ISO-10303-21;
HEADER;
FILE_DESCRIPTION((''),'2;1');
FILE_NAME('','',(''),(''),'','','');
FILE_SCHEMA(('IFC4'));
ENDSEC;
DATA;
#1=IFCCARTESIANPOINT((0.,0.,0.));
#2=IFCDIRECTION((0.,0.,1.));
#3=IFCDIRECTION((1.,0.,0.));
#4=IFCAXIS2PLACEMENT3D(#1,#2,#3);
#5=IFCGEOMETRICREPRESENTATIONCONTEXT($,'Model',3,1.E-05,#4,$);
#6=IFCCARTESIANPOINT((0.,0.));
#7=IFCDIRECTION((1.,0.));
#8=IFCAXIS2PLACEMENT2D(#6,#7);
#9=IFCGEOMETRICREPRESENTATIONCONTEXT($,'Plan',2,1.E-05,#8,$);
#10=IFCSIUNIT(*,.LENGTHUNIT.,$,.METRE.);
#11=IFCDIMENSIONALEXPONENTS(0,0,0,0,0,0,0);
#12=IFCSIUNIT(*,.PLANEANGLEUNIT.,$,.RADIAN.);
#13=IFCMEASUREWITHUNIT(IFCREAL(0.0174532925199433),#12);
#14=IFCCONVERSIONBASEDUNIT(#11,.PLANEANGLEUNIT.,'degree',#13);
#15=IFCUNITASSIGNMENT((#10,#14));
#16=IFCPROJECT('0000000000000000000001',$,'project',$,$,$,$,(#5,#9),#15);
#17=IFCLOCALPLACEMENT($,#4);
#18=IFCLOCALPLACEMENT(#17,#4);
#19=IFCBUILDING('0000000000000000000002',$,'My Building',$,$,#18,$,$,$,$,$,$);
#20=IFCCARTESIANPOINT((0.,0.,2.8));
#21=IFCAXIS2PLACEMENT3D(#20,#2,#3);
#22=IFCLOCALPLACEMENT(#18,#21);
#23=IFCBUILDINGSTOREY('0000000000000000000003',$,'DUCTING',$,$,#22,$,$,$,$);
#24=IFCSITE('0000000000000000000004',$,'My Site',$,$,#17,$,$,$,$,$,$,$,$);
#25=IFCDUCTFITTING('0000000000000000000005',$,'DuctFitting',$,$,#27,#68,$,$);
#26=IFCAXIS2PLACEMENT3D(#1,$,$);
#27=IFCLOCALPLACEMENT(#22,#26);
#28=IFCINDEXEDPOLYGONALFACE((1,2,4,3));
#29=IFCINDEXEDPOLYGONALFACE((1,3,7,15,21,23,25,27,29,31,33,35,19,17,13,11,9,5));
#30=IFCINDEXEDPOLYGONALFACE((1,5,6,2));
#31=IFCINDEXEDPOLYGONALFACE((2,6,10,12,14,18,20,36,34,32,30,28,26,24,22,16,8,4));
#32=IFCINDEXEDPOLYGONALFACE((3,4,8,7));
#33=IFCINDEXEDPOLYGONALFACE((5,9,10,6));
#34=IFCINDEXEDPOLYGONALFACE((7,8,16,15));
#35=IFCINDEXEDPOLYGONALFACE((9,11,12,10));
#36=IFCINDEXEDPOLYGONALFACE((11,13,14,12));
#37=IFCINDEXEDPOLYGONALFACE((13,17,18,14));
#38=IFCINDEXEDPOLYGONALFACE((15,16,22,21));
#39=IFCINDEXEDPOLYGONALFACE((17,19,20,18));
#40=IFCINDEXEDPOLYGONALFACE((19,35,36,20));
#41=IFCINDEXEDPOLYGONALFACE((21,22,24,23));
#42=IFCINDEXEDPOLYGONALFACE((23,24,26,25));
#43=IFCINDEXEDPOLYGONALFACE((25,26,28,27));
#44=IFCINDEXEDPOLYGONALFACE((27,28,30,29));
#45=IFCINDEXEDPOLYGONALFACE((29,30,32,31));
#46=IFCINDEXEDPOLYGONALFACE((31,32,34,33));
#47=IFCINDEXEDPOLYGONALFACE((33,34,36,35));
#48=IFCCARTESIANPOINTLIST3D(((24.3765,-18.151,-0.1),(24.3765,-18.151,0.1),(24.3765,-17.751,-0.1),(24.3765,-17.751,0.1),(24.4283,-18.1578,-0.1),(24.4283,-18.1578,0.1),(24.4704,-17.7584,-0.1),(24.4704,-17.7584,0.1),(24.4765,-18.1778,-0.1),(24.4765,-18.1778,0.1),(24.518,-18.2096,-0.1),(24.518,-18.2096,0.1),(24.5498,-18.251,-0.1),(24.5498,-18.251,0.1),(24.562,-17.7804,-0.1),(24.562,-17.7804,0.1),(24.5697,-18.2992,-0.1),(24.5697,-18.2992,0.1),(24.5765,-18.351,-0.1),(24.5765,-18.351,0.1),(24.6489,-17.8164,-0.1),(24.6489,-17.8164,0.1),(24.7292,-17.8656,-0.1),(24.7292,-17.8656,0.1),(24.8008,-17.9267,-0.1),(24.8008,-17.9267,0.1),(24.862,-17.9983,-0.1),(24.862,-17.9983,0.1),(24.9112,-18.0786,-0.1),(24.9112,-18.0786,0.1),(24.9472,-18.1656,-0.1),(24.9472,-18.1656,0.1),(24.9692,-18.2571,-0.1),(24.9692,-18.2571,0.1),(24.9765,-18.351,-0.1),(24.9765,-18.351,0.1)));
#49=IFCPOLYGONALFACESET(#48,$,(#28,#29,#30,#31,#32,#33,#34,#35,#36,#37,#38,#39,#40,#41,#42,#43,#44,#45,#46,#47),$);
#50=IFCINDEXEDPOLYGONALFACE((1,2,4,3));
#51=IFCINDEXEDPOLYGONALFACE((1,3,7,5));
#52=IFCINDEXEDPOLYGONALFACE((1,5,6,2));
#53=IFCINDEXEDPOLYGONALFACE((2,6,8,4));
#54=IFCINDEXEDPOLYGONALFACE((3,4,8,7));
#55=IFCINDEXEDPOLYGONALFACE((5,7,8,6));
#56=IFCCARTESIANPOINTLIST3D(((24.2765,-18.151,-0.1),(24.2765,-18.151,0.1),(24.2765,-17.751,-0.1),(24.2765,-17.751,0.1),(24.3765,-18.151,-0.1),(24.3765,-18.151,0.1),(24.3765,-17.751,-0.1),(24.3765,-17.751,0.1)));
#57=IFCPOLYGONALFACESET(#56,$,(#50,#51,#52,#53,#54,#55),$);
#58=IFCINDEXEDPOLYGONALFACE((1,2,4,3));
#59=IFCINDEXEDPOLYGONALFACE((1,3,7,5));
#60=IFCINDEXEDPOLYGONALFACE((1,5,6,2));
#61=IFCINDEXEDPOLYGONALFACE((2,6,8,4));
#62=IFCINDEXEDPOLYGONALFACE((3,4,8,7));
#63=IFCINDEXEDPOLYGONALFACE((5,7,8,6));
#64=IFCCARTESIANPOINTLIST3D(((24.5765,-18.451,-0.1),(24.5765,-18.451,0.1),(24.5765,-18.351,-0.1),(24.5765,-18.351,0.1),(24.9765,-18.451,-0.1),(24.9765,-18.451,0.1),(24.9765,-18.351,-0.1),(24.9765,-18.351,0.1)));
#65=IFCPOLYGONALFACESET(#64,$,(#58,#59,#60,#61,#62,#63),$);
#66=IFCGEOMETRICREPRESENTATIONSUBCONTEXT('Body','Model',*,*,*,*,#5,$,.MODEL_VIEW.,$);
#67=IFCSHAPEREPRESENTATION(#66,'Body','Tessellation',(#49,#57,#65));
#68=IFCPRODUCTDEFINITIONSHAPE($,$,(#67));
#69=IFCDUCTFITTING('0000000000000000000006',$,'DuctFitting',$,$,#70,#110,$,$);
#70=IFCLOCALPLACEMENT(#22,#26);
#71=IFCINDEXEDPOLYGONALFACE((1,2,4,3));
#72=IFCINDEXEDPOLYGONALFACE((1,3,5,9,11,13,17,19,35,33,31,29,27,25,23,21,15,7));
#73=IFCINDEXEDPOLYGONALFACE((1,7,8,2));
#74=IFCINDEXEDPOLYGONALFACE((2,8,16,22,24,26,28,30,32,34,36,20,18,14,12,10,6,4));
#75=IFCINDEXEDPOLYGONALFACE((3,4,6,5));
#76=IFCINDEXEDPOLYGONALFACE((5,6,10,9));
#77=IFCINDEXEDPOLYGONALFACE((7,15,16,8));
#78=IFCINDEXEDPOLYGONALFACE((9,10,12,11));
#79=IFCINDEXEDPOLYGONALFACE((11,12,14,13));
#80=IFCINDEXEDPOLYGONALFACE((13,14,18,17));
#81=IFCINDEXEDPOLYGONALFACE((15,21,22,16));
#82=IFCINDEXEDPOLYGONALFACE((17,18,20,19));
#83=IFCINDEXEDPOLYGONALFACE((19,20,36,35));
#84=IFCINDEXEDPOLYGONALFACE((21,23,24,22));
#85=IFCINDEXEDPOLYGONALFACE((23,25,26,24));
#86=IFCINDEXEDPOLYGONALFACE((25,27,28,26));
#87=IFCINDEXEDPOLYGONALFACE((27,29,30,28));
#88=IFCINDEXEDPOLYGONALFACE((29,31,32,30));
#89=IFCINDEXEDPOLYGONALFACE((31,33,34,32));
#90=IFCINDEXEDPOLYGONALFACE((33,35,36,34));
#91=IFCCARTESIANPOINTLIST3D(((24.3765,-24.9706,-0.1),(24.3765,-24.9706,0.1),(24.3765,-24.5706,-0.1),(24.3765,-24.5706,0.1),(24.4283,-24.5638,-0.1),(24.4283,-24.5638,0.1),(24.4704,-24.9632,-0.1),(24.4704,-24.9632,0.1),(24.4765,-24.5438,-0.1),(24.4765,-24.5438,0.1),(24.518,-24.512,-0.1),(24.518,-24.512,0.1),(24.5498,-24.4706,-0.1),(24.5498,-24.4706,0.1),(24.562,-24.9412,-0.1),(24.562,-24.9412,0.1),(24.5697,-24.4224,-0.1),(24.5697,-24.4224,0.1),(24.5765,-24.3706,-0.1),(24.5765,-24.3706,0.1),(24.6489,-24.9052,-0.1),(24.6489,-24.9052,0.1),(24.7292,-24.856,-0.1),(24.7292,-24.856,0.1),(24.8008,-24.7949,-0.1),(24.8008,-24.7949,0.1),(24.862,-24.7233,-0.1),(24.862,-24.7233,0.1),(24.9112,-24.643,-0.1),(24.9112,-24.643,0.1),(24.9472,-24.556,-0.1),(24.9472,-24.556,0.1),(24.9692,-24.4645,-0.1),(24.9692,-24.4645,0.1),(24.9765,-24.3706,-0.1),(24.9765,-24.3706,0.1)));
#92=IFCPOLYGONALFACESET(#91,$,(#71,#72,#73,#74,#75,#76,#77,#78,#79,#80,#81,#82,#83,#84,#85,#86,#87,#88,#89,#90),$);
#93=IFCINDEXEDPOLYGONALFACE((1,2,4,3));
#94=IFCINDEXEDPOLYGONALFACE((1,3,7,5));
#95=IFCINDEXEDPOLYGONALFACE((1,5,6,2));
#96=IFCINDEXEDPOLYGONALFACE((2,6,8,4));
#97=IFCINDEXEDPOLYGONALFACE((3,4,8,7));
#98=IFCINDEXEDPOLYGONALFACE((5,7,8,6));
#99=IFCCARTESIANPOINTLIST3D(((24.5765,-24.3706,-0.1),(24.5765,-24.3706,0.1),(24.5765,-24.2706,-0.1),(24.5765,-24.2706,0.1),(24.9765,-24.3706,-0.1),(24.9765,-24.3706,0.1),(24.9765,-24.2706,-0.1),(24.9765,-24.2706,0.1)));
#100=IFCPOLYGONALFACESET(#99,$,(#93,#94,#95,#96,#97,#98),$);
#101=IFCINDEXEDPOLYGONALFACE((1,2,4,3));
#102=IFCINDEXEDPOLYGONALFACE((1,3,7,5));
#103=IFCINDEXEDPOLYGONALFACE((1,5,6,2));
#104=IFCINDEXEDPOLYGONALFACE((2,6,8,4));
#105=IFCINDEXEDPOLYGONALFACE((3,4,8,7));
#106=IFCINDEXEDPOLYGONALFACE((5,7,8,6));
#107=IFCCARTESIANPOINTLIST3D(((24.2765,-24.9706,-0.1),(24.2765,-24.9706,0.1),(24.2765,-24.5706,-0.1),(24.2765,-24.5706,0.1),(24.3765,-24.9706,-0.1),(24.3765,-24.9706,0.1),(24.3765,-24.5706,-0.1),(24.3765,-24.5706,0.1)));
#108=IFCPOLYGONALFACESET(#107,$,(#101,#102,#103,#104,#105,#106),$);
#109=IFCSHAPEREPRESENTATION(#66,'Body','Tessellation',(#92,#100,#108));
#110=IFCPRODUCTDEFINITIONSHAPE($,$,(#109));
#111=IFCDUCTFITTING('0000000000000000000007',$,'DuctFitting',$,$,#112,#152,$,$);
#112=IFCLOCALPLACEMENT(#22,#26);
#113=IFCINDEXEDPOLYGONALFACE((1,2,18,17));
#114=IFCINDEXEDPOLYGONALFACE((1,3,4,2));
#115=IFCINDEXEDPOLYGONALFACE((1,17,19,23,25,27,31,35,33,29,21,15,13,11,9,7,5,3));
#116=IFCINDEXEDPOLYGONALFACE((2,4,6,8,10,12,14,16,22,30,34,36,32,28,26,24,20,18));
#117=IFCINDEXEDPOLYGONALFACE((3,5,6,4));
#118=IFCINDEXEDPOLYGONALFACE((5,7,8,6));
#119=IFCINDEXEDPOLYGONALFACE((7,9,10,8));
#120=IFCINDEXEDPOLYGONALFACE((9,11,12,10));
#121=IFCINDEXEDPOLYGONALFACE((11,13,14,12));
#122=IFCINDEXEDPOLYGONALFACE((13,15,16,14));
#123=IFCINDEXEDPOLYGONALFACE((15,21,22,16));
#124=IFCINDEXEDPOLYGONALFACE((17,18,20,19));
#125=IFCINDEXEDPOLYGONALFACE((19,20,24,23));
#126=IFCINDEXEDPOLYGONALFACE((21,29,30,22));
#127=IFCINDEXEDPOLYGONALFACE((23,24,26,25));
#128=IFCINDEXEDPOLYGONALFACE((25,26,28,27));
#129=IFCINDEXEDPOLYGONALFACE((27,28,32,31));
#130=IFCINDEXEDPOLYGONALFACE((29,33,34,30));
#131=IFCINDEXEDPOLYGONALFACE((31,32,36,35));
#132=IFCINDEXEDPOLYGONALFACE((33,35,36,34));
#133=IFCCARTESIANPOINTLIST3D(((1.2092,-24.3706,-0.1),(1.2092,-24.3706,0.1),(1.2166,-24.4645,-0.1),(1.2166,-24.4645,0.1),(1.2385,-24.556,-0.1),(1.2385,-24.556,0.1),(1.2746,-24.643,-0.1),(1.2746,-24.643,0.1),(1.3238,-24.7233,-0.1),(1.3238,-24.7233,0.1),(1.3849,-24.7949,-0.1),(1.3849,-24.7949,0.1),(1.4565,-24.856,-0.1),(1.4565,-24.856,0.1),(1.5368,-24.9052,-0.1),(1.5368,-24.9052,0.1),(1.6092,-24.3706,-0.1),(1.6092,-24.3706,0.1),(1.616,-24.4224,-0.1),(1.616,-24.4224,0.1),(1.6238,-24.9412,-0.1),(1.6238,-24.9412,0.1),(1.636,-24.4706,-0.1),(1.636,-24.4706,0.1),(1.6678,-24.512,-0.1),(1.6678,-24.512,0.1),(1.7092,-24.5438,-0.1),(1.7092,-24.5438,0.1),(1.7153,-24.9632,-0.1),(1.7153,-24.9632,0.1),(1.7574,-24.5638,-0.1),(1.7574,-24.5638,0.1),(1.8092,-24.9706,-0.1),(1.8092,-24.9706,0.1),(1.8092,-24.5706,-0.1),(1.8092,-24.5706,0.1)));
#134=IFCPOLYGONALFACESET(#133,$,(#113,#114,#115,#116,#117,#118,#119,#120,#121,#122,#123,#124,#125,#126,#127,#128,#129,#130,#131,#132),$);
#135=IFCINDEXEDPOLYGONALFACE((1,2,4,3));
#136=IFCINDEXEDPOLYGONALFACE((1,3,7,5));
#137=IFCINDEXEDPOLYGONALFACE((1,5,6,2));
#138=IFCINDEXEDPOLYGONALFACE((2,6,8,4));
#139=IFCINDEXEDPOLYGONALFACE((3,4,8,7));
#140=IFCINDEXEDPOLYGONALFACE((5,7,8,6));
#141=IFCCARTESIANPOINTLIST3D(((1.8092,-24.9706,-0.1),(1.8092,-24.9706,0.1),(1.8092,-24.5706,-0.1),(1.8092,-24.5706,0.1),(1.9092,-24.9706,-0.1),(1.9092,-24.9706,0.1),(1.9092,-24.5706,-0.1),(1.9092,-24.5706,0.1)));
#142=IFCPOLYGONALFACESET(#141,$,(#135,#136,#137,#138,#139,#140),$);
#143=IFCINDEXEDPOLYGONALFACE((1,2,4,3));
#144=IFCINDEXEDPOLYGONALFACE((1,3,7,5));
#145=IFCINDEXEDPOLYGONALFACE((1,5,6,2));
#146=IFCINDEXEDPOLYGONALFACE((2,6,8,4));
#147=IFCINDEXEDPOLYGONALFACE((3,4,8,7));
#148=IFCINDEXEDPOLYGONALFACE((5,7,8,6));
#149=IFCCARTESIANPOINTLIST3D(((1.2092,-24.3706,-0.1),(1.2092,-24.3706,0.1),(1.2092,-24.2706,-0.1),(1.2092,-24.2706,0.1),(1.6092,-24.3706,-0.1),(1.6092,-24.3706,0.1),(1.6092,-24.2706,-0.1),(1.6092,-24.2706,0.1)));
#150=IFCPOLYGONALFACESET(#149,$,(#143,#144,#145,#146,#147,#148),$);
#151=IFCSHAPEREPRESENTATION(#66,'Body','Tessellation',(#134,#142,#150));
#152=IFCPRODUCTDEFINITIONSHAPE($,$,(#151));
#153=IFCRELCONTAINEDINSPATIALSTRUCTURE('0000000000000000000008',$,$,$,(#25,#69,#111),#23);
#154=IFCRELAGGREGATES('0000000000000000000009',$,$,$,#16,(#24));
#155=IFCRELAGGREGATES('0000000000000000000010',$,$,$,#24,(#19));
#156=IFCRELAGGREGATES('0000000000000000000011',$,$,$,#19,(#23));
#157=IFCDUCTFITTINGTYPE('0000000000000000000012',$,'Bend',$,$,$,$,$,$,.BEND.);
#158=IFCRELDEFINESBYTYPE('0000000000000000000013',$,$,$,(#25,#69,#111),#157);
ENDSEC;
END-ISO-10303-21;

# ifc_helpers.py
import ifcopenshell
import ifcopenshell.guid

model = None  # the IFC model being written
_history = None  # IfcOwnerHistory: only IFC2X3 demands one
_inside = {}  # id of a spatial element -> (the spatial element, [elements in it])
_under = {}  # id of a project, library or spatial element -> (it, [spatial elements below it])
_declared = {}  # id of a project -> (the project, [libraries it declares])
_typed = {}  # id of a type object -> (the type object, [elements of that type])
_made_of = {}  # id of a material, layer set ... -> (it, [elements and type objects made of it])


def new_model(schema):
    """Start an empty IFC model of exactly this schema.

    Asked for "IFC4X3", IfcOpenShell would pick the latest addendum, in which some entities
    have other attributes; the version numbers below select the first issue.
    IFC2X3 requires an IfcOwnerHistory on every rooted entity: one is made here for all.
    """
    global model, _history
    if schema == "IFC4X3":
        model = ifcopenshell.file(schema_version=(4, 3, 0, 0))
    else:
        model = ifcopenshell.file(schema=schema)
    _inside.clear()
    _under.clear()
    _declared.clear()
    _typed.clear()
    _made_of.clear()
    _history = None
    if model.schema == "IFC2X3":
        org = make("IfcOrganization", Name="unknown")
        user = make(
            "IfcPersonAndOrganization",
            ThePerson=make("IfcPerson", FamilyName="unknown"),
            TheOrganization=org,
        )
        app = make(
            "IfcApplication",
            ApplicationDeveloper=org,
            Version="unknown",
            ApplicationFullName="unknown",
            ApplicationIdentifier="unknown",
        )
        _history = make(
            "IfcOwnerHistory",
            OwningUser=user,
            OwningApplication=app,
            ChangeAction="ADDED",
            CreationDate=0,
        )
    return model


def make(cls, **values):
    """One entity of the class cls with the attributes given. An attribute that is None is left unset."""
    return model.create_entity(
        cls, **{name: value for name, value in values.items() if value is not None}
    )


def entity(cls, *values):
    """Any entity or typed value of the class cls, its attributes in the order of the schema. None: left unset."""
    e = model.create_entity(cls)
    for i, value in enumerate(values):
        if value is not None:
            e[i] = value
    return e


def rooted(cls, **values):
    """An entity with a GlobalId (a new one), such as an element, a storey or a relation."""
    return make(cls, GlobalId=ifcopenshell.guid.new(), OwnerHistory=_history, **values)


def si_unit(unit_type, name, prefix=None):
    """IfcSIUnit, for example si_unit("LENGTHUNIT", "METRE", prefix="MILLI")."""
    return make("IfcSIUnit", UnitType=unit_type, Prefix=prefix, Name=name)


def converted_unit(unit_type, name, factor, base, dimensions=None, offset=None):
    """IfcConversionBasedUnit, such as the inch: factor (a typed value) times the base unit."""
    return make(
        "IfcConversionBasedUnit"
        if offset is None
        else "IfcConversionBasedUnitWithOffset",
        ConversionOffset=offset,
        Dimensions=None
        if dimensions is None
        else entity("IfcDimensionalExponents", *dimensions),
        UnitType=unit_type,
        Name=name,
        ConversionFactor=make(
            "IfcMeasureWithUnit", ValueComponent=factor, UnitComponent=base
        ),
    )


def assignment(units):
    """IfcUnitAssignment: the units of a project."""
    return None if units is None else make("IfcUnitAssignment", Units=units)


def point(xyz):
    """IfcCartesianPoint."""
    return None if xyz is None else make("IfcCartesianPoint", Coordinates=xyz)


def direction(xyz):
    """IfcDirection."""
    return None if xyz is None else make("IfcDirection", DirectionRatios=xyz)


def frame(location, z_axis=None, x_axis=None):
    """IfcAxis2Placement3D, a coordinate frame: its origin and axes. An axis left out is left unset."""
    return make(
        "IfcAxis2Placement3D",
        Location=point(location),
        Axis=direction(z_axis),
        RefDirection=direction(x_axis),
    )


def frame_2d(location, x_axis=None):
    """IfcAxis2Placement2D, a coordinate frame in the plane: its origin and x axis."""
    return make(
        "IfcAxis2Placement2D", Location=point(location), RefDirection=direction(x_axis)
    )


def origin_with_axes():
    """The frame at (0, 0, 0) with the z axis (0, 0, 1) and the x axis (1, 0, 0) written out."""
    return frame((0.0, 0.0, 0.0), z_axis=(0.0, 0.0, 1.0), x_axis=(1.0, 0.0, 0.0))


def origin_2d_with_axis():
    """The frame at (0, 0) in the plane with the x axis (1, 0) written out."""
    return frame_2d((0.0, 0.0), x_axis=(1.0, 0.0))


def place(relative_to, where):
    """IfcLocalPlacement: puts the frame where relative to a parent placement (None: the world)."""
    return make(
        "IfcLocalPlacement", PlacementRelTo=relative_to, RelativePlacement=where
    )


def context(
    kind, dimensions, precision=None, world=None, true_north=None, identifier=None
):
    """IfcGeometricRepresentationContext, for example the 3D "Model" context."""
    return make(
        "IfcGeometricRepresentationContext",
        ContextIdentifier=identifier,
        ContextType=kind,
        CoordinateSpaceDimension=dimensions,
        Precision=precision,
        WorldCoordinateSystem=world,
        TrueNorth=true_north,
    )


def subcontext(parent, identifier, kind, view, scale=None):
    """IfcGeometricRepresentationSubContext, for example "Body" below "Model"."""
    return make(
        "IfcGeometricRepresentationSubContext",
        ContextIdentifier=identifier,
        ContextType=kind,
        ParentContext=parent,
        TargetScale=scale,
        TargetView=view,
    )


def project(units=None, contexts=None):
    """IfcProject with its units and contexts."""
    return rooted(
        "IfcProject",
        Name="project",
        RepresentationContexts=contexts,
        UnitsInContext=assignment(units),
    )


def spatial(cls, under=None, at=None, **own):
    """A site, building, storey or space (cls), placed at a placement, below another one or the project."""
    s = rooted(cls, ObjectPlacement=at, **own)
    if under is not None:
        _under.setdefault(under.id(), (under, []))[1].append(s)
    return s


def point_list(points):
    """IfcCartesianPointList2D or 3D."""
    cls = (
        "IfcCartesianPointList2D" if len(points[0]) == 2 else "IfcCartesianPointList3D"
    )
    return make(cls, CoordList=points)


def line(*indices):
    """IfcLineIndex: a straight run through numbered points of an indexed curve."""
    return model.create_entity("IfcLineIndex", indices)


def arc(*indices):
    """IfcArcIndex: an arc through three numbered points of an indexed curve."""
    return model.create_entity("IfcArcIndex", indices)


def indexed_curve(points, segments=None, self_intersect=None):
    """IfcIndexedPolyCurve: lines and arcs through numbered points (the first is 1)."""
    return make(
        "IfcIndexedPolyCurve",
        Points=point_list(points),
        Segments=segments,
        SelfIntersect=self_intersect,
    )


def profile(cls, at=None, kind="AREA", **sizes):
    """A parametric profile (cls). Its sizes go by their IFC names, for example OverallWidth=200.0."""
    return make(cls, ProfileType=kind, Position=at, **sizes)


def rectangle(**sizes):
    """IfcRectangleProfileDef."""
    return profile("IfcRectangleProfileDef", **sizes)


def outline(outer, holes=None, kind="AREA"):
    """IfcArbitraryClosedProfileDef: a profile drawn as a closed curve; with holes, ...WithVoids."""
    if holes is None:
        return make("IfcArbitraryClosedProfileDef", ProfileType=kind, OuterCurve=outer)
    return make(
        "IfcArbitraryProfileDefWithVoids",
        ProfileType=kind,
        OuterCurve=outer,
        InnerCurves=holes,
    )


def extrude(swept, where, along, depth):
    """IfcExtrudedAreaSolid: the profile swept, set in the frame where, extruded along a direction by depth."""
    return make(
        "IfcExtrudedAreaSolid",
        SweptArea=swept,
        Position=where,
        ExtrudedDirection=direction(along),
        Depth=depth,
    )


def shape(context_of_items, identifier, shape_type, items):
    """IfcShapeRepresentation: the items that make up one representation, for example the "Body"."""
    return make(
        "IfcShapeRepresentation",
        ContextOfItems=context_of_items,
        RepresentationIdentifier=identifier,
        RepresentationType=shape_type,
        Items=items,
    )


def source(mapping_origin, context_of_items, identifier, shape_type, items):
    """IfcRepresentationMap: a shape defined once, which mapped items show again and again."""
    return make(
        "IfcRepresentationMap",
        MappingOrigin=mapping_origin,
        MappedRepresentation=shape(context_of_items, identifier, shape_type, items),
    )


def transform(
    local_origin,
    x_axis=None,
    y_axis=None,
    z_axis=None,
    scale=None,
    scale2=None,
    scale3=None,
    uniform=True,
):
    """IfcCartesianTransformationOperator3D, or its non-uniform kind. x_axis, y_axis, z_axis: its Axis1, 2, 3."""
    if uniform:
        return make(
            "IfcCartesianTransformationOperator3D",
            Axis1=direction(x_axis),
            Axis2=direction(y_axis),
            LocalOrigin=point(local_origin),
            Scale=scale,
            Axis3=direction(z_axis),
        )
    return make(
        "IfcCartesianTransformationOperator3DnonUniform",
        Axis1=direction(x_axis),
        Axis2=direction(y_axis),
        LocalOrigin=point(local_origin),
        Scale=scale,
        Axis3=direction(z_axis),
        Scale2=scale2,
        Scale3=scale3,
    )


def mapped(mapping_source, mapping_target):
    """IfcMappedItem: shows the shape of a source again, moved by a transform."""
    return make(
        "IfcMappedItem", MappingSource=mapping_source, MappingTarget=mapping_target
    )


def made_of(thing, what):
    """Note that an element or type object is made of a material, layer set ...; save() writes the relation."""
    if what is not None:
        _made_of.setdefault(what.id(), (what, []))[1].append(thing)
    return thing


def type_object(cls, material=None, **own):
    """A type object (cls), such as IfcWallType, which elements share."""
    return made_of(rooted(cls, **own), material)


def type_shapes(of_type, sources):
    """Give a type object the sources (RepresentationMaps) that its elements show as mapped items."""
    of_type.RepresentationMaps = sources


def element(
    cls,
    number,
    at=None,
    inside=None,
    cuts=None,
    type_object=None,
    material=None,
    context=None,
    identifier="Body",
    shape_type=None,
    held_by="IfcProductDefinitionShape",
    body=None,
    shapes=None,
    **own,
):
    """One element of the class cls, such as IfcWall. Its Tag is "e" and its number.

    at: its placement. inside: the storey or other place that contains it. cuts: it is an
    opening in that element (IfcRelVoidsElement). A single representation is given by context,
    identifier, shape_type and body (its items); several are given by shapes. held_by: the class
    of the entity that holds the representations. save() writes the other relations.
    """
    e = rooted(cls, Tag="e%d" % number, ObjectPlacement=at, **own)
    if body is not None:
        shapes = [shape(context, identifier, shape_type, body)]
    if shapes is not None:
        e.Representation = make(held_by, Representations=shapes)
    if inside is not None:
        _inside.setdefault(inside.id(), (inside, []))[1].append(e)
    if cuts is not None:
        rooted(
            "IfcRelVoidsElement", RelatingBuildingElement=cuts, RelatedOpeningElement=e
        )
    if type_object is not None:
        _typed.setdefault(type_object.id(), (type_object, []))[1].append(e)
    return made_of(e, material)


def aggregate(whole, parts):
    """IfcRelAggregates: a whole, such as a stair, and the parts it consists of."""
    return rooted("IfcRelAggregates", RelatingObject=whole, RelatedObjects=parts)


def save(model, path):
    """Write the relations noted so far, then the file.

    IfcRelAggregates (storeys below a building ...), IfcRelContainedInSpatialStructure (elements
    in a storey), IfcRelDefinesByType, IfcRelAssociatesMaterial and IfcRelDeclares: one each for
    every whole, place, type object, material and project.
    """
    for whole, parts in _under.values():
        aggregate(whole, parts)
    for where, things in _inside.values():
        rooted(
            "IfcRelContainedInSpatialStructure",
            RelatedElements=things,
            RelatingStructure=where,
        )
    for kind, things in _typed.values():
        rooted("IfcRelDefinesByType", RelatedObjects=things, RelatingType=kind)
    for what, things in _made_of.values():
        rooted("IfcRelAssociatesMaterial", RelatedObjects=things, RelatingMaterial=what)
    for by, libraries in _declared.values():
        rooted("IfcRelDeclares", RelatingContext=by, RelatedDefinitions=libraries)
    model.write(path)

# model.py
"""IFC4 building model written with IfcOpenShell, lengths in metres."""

from ifc_helpers import new_model, entity, si_unit, converted_unit, frame, origin_with_axes, origin_2d_with_axis, place, context, subcontext, project, spatial, line, arc, indexed_curve, rectangle, outline, extrude, source, transform, mapped, type_object, type_shapes, element, save


model = new_model("IFC4")

# Units and contexts
model_context = context("Model", 3, precision=1e-05, world=origin_with_axes())
plan_context = context("Plan", 2, precision=1e-05, world=origin_2d_with_axis())
body_context = subcontext(model_context, "Body", "Model", "MODEL_VIEW")
ifc_project = project(units=[si_unit("LENGTHUNIT", "METRE"), converted_unit("PLANEANGLEUNIT", "degree", entity("IfcReal", 0.0174532925199433), si_unit("PLANEANGLEUNIT", "RADIAN"), dimensions=[0, 0, 0, 0, 0, 0, 0])], contexts=[model_context, plan_context])

# Site, building, storey
site_placement = place(None, origin_with_axes())
site = spatial("IfcSite", under=ifc_project, at=site_placement, Name="My Site")
building_placement = place(site_placement, origin_with_axes())
building = spatial("IfcBuilding", under=site, at=building_placement, Name="My Building")
storey_placement = place(building_placement, frame((0.0, 0.0, 2.8), z_axis=(0.0, 0.0, 1.0), x_axis=(1.0, 0.0, 0.0)))
storey = spatial("IfcBuildingStorey", under=building, at=storey_placement, Name="DUCTING")

# Duct fittings
duct_fitting_type = type_object("IfcDuctFittingType", Name="Bend", PredefinedType="BEND")
shared_shape = source(origin_with_axes(), body_context, "Body", "SweptSolid", [
    extrude(outline(indexed_curve([(-0.2, 0.0), (-0.2586, -0.1414), (-0.4, -0.2), (-0.4, -0.6), (0.0243, -0.4243), (0.2, 0.0)], segments=[arc(1, 2, 3), line(3, 4), arc(4, 5, 6), line(6, 1)])), frame((0.0, -0.1, -0.1), z_axis=(0.0, -1.0, 0.0), x_axis=(1.0, 0.0, 0.0)), (0.0, 0.0, -1.0), 0.2),
    extrude(rectangle(XDim=0.4, YDim=0.2), origin_with_axes(), (0.0, 0.0, -1.0), 0.1),
    extrude(rectangle(XDim=0.4, YDim=0.2), frame((-0.4, 0.0, -0.5), z_axis=(-1.0, 0.0, 0.000001), x_axis=(-0.000001, 0.0, -1.0)), (0.0, 0.0, 1.0), 0.1),
])
type_shapes(duct_fitting_type, [shared_shape])
for number, where, z_axis, x_axis, name in (
    (1, (24.2765, -17.951, 0.0), (-1.0, 0.000001, -0.000001), (0.000001, 1.0, 0.0), "DuctFitting"),
    (2, (24.7765, -24.2706, 0.0), (0.0, 1.0, 0.0), (1.0, 0.0, 0.0), "DuctFitting"),
    (3, (1.9092, -24.7706, 0.0), (1.0, -0.000001, 0.000001), (-0.000001, -1.0, 0.0), "DuctFitting"),
):
    element("IfcDuctFitting", number, at=place(storey_placement, frame(where, z_axis=z_axis, x_axis=x_axis)), inside=storey, type_object=duct_fitting_type, Name=name, context=body_context, shape_type="MappedRepresentation", body=[
        mapped(shared_shape, transform((0.0, 0.0, 0.0), x_axis=(1.0, 0.0, 0.0), y_axis=(0.0, 1.0, 0.0), z_axis=(0.0, 0.0, 1.0), scale=1.0)),
    ])

save(model, "model.ifc")
